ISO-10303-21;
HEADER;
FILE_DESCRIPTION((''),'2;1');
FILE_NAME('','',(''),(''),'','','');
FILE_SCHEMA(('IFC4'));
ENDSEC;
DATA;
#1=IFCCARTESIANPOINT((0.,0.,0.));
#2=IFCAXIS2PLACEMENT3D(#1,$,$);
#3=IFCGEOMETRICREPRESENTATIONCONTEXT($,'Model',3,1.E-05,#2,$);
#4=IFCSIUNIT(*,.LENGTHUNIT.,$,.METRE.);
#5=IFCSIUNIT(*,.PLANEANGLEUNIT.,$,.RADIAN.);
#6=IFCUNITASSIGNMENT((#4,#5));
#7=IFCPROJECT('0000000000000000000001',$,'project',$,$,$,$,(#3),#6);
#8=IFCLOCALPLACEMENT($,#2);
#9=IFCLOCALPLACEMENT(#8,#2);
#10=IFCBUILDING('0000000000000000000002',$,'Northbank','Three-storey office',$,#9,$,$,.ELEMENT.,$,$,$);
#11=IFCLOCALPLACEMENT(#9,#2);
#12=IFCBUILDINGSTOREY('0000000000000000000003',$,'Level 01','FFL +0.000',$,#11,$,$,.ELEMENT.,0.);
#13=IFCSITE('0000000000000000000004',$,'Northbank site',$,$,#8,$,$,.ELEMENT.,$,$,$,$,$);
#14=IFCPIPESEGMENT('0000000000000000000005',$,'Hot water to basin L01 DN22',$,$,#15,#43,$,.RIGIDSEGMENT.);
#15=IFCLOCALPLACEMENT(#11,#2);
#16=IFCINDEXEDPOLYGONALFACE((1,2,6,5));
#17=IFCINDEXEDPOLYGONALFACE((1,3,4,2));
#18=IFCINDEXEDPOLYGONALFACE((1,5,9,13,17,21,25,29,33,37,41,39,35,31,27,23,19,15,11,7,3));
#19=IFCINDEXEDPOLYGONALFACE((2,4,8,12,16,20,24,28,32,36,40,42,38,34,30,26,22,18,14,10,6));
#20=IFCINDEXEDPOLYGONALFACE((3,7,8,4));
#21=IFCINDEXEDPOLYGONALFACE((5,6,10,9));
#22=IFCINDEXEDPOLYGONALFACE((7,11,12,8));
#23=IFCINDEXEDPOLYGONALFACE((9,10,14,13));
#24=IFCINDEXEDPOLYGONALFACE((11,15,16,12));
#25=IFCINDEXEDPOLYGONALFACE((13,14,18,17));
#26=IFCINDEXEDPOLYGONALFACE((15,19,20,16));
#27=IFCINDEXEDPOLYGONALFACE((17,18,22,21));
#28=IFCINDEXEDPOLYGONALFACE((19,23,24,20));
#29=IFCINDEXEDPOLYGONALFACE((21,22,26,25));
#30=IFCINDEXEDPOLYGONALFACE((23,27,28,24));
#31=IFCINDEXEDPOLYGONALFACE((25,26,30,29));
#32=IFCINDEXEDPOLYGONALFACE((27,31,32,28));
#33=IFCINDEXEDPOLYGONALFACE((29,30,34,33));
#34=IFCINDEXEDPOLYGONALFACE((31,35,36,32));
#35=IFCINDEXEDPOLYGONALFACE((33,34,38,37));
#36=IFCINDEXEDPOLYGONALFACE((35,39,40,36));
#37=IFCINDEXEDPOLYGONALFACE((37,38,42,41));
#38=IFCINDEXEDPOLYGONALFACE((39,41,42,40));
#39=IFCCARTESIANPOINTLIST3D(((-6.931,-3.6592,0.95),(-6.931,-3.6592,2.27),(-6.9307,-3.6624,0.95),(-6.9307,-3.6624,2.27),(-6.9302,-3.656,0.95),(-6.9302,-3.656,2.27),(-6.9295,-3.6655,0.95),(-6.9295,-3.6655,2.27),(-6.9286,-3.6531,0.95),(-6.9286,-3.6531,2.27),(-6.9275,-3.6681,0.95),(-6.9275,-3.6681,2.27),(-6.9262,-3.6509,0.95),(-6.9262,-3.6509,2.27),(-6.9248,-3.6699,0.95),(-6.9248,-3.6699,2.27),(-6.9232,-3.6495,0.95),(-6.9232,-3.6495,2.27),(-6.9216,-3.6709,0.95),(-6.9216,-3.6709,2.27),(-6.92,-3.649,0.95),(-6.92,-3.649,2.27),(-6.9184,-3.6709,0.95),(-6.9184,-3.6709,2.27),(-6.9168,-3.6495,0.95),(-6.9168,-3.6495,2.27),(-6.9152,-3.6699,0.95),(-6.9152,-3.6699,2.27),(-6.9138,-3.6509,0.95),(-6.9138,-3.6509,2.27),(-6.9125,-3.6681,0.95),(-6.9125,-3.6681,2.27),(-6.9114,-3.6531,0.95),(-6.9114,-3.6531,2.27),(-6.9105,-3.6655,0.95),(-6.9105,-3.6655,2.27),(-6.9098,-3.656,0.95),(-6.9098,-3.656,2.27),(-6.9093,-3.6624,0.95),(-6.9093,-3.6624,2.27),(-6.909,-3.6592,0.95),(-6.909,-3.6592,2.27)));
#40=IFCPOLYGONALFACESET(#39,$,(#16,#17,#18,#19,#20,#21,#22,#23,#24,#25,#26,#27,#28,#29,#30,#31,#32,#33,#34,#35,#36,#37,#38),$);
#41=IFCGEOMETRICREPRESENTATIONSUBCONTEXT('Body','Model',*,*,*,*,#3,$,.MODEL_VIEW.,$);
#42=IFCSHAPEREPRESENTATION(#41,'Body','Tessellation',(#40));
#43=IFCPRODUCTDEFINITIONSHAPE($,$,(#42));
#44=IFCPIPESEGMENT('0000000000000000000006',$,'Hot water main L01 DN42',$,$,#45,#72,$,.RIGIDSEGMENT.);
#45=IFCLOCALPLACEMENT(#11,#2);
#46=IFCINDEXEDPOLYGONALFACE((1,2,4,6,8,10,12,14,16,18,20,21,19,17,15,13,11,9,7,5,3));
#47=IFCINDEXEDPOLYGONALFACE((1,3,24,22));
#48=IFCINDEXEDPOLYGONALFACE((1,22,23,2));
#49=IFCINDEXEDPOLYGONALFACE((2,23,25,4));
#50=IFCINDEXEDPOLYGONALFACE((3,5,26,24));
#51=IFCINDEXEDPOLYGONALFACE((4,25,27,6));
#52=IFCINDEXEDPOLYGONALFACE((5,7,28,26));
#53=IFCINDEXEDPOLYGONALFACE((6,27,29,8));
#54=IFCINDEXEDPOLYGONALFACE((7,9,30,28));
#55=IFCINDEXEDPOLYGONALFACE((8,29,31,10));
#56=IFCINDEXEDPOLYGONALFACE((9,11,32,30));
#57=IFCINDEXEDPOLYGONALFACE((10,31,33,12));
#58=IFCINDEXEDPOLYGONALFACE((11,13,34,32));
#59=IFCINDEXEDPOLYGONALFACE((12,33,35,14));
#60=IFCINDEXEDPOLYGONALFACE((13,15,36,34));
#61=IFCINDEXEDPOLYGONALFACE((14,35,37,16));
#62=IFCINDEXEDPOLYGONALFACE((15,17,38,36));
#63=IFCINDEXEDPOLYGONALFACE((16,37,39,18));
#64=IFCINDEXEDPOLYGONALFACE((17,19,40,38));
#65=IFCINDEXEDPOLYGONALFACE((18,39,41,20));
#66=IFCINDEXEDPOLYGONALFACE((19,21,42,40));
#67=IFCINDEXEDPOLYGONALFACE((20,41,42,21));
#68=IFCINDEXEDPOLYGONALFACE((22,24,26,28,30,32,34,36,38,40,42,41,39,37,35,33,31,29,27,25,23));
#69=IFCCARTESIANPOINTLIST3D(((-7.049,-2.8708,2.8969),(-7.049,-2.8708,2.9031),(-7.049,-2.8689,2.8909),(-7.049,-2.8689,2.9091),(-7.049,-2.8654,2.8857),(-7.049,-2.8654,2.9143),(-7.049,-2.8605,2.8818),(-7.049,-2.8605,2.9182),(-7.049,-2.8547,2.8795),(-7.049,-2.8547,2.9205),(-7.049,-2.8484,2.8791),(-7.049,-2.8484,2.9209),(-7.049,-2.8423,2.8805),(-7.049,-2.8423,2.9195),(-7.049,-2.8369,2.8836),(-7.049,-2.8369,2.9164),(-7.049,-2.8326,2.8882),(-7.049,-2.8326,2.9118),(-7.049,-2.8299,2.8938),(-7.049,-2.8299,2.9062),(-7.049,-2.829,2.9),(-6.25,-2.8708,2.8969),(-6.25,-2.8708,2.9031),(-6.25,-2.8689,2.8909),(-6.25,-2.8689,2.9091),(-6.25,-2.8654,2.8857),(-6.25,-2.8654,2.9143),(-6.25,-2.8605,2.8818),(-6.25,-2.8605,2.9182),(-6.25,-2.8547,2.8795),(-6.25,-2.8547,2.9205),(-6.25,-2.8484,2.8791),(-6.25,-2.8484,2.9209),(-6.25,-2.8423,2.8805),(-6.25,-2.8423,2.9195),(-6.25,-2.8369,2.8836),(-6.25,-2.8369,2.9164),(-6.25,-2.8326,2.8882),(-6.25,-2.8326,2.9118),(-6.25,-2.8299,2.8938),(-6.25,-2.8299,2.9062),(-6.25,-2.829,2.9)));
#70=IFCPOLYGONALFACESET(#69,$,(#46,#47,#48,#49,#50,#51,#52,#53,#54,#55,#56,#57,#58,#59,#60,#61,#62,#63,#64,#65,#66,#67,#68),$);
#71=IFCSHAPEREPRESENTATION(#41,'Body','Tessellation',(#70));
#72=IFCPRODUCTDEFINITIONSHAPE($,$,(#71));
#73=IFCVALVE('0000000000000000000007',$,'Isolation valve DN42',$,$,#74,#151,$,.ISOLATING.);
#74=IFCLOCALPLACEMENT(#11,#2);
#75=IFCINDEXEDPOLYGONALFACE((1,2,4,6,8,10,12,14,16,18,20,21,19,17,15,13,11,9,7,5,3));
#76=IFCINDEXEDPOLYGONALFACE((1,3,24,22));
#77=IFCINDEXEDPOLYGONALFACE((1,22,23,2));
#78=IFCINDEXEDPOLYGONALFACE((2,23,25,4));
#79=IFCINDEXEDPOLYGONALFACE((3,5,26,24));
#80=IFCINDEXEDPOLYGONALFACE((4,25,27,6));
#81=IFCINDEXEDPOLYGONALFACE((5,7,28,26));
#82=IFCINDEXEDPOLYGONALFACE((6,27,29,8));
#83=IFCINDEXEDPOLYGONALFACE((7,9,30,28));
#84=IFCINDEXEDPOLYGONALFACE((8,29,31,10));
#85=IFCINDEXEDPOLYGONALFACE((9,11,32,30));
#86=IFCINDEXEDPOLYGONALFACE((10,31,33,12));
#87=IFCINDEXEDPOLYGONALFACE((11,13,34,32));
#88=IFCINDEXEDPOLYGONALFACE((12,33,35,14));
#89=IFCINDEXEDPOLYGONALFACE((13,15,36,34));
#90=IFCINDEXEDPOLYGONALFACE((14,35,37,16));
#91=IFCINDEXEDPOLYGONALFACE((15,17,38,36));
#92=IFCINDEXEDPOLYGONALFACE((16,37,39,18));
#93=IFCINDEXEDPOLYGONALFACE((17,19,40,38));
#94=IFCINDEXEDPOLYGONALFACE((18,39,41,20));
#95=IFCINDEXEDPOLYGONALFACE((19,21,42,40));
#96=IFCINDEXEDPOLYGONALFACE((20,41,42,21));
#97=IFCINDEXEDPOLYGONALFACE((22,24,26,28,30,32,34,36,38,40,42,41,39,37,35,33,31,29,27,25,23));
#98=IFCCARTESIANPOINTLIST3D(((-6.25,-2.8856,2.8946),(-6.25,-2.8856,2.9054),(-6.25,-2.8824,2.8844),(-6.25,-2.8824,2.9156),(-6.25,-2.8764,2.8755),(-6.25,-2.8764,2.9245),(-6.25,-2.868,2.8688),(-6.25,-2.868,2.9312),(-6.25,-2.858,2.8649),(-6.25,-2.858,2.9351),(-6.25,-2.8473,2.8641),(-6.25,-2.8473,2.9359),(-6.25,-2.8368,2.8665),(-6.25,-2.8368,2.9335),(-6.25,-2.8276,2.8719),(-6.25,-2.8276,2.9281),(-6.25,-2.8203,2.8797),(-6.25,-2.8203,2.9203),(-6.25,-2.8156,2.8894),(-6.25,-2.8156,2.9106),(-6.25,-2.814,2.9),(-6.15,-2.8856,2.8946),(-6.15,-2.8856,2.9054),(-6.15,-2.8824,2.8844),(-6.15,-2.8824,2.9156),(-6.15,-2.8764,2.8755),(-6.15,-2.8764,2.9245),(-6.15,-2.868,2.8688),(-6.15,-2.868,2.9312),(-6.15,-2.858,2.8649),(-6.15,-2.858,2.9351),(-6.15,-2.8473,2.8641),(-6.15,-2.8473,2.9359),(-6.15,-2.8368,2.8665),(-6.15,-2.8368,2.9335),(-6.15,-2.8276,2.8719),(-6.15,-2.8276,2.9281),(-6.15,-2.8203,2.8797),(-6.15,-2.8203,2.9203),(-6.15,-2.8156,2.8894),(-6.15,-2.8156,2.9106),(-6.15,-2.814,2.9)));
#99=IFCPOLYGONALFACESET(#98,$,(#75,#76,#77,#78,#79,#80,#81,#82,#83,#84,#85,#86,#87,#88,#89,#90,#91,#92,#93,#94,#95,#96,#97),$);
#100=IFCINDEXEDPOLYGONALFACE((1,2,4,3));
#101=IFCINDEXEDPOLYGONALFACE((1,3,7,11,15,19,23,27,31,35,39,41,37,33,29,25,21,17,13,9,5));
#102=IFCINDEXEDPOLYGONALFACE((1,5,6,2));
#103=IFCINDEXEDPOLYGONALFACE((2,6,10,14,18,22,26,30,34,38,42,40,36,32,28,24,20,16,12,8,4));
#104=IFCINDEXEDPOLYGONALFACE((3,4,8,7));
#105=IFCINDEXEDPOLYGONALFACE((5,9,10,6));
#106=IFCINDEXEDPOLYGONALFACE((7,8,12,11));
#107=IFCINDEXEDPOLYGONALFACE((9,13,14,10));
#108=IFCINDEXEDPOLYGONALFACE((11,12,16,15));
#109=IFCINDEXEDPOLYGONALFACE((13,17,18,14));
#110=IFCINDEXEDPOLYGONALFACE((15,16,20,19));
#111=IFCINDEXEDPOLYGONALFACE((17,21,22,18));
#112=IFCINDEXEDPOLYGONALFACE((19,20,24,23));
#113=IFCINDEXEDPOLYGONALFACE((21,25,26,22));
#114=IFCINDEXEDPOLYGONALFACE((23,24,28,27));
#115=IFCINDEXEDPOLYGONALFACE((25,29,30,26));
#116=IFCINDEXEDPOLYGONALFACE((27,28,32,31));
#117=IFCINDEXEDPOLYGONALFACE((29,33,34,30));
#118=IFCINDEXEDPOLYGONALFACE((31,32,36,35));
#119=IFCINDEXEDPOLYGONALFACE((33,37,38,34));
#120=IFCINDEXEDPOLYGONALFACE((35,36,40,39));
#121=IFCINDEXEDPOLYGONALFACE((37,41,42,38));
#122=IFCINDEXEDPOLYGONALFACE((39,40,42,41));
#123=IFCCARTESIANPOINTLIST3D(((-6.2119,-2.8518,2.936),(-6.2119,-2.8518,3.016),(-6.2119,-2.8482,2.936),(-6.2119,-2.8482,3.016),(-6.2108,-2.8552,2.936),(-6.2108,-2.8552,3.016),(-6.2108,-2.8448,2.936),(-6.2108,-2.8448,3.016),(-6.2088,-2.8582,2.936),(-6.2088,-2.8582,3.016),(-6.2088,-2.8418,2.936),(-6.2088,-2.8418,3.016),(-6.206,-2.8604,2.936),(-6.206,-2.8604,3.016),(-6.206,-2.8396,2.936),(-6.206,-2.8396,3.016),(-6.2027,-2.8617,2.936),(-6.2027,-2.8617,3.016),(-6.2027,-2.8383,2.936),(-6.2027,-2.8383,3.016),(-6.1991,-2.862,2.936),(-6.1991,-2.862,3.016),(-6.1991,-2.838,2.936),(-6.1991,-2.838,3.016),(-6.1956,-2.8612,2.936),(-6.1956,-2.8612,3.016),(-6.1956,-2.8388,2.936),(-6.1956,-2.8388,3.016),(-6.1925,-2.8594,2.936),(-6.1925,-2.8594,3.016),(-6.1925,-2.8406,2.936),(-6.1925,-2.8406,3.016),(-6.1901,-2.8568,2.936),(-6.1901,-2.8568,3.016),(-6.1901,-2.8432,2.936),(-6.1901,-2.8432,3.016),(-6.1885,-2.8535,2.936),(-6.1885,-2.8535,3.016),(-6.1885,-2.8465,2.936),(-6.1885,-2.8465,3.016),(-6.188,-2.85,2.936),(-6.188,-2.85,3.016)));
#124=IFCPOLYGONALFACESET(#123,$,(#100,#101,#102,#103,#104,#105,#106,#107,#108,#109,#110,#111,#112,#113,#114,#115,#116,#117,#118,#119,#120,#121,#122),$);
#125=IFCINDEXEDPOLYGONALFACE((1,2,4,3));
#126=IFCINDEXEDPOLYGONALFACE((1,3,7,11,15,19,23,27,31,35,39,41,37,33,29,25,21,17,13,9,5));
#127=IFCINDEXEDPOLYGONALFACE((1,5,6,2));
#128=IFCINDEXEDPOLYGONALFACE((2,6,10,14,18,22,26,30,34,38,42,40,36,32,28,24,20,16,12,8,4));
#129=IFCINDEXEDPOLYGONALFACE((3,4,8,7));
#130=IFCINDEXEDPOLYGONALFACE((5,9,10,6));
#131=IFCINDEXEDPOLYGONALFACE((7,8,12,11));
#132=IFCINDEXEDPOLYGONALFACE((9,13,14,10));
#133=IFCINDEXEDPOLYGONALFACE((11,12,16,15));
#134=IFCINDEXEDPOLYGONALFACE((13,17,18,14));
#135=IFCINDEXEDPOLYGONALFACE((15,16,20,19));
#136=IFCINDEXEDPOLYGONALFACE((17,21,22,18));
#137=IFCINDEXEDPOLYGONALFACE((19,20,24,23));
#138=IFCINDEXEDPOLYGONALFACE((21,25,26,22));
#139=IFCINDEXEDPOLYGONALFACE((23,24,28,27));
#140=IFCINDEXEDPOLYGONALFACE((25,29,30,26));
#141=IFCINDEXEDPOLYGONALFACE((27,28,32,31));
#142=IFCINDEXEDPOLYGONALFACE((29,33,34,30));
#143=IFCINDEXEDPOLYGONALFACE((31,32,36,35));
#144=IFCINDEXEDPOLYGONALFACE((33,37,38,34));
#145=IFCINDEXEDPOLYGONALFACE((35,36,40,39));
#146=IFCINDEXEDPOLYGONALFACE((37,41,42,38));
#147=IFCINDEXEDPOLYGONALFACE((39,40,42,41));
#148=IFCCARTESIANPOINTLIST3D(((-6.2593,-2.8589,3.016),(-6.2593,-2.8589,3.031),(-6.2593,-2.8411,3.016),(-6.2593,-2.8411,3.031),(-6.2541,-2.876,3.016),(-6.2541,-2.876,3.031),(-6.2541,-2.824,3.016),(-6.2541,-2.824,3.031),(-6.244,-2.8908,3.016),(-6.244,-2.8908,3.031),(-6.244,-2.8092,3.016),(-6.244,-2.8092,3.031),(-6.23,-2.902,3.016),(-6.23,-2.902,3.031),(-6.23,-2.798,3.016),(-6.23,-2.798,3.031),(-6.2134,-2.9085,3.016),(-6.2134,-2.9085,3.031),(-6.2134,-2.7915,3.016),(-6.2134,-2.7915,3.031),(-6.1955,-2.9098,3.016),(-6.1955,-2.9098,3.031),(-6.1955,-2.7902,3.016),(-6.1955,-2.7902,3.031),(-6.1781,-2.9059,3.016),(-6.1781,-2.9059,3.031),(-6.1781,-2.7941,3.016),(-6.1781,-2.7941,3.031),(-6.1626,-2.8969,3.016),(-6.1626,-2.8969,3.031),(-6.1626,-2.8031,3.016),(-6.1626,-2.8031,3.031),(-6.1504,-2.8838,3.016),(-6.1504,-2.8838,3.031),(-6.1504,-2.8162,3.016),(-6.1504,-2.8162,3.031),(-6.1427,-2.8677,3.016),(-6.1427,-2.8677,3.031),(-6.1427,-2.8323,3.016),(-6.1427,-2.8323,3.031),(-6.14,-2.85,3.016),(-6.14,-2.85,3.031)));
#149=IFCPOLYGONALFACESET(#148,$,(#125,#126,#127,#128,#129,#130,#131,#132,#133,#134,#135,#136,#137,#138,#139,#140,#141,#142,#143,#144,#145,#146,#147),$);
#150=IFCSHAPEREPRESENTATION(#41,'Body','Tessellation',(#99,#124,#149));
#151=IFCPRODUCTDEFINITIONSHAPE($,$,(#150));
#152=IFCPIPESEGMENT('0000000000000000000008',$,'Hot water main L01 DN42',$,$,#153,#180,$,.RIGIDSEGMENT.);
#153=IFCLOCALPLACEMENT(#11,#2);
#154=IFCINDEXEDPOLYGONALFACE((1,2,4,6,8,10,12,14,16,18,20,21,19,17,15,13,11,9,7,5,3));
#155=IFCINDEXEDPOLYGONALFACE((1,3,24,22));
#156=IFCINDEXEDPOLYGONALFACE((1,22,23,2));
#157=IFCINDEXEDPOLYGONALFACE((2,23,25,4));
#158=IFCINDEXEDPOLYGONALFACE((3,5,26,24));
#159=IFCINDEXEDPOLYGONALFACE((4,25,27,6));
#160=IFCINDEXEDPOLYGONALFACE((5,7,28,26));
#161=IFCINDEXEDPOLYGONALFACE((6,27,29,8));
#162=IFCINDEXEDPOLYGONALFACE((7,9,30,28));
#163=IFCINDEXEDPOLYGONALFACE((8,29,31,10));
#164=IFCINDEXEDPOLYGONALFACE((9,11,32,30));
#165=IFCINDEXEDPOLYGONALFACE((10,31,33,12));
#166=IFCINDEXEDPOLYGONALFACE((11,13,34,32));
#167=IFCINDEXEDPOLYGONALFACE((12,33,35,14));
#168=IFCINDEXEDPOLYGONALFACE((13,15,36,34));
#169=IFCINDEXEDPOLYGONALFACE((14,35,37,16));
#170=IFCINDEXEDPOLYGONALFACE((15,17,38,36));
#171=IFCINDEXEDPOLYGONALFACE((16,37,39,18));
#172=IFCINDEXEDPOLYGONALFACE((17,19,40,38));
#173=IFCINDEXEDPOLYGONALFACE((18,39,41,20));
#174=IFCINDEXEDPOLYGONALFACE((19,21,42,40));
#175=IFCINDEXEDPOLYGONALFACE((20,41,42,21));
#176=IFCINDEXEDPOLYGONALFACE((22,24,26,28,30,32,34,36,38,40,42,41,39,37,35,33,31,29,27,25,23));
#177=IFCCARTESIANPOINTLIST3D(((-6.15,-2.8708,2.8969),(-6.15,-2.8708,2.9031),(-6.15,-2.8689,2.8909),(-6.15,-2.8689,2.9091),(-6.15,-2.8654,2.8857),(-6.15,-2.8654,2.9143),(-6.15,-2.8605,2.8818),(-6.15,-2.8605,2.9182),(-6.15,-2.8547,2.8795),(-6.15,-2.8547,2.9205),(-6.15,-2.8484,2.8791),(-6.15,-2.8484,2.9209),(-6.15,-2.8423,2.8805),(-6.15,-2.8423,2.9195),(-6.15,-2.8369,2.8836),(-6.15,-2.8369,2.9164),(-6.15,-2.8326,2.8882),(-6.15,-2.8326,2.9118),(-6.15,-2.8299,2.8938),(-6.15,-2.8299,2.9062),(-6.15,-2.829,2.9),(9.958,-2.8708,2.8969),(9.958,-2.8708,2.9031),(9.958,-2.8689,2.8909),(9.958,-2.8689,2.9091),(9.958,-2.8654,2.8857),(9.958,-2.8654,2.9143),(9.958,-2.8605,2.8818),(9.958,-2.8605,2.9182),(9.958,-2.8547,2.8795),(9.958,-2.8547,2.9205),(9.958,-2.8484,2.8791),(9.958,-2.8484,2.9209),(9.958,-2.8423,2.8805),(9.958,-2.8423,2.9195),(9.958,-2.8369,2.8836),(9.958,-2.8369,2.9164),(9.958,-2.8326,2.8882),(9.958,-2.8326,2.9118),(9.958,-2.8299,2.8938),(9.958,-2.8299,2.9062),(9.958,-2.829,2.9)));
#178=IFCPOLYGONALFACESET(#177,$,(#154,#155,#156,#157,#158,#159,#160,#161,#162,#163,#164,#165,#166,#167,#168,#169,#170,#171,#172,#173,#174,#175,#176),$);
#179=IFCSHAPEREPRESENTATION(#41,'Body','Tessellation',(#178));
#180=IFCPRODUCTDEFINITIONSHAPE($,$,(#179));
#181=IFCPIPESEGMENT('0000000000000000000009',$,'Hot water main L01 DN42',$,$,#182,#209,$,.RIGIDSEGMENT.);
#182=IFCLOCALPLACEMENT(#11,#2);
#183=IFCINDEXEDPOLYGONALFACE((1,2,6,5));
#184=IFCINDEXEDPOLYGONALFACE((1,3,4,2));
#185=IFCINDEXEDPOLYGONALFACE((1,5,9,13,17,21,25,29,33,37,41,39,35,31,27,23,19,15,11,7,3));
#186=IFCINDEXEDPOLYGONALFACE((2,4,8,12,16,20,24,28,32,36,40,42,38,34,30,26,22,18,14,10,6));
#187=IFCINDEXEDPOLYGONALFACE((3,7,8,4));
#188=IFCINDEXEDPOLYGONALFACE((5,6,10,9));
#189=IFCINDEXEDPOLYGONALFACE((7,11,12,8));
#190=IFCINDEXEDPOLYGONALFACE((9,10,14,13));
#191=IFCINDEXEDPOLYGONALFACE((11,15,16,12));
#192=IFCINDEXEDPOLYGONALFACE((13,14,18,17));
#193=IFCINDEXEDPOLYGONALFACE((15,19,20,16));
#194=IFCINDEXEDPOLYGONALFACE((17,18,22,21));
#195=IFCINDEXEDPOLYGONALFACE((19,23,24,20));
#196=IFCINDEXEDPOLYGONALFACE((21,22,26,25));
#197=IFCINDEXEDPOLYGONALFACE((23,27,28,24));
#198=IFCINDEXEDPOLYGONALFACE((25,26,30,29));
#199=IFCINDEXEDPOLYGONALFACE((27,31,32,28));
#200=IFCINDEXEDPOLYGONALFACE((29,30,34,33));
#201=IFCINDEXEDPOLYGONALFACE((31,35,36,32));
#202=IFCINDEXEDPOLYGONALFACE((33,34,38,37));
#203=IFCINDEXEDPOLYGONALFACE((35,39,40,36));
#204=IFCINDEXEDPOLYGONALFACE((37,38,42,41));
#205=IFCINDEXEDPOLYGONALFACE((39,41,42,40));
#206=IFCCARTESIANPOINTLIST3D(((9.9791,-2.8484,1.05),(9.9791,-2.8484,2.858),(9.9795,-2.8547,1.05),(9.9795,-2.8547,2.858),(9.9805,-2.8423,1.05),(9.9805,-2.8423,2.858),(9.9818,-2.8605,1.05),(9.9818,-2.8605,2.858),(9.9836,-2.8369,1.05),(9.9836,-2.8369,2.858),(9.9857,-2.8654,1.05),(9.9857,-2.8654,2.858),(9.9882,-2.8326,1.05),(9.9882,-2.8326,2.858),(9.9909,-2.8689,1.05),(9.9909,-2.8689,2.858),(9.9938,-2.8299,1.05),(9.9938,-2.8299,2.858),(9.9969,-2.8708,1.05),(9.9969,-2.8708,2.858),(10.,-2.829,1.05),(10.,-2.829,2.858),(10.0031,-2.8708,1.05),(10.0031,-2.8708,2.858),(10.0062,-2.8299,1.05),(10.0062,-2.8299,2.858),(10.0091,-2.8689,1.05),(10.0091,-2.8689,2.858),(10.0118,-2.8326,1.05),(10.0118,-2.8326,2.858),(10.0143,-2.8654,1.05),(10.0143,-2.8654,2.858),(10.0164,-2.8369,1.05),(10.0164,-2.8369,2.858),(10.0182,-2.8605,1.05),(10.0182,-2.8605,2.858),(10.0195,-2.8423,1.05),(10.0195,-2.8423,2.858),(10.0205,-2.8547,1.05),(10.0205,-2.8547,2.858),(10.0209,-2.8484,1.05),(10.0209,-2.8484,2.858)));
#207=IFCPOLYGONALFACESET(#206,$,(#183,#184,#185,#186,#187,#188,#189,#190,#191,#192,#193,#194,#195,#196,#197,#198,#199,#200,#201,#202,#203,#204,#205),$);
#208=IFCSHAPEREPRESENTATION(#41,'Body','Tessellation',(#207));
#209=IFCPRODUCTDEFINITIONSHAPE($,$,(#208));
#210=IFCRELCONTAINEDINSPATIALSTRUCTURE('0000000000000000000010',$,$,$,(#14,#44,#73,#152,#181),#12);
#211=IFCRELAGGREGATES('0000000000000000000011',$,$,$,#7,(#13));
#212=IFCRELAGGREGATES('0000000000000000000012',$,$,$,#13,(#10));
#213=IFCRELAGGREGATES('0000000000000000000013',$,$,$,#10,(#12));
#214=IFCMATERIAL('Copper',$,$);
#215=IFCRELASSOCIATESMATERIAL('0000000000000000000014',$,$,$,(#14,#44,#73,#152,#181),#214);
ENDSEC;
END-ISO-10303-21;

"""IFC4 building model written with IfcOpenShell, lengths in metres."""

from ifc_helpers import new_model, si_unit, frame, origin, place, context, subcontext, project, spatial, circle, extrude, material, element, save


model = new_model("IFC4")

# Units and contexts
model_context = context("Model", 3, precision=1e-05, world=origin())
body_context = subcontext(model_context, "Body", "Model", "MODEL_VIEW")
ifc_project = project(units=[si_unit("LENGTHUNIT", "METRE"), si_unit("PLANEANGLEUNIT", "RADIAN")], contexts=[model_context])

# Site, building, storey
site_placement = place(None, origin())
site = spatial("IfcSite", under=ifc_project, at=site_placement, Name="Northbank site", CompositionType="ELEMENT")
building_placement = place(site_placement, origin())
building = spatial("IfcBuilding", under=site, at=building_placement, Name="Northbank", Description="Three-storey office", CompositionType="ELEMENT")
storey_placement = place(building_placement, origin())
storey = spatial("IfcBuildingStorey", under=building, at=storey_placement, Name="Level 01", Description="FFL +0.000", CompositionType="ELEMENT", Elevation=0.0)

# Pipe segments
ifc_material_1 = material(Name="Copper")
pipe_segment_1_placement = place(storey_placement, origin())
element("IfcPipeSegment", 1, at=pipe_segment_1_placement, inside=storey, material=ifc_material_1, Name="Hot water to basin L01 DN22", PredefinedType="RIGIDSEGMENT", context=body_context, shape_type="SweptSolid", body=[
    extrude(circle(Radius=0.011), frame((-6.92, -3.66, 2.27), z_axis=(0.0, 0.0, -1.0), x_axis=(0.0, 1.0, 0.0)), (0.0, 0.0, 1.0), 1.32),
])
pipe_segment_2_placement = place(storey_placement, origin())
element("IfcPipeSegment", 2, at=pipe_segment_2_placement, inside=storey, material=ifc_material_1, Name="Hot water main L01 DN42", PredefinedType="RIGIDSEGMENT", context=body_context, shape_type="SweptSolid", body=[
    extrude(circle(Radius=0.021), frame((-7.049, -2.85, 2.9), z_axis=(1.0, 0.0, 0.0), x_axis=(0.0, 1.0, 0.0)), (0.0, 0.0, 1.0), 0.799),
])

# Valve
valve_placement = place(storey_placement, origin())
element("IfcValve", 3, at=valve_placement, inside=storey, material=ifc_material_1, Name="Isolation valve DN42", PredefinedType="ISOLATING", context=body_context, shape_type="SweptSolid", body=[
    extrude(circle(Radius=0.036), frame((-6.25, -2.85, 2.9), z_axis=(1.0, 0.0, 0.0), x_axis=(0.0, 1.0, 0.0)), (0.0, 0.0, 1.0), 0.1),
    extrude(circle(Radius=0.012), frame((-6.2, -2.85, 2.936), z_axis=(0.0, 0.0, 1.0), x_axis=(1.0, 0.0, 0.0)), (0.0, 0.0, 1.0), 0.08),
    extrude(circle(Radius=0.06), frame((-6.2, -2.85, 3.016), z_axis=(0.0, 0.0, 1.0), x_axis=(1.0, 0.0, 0.0)), (0.0, 0.0, 1.0), 0.015),
])

# Pipe segments
pipe_segment_3_placement = place(storey_placement, origin())
element("IfcPipeSegment", 4, at=pipe_segment_3_placement, inside=storey, material=ifc_material_1, Name="Hot water main L01 DN42", PredefinedType="RIGIDSEGMENT", context=body_context, shape_type="SweptSolid", body=[
    extrude(circle(Radius=0.021), frame((-6.15, -2.85, 2.9), z_axis=(1.0, 0.0, 0.0), x_axis=(0.0, 1.0, 0.0)), (0.0, 0.0, 1.0), 16.108),
])
pipe_segment_4_placement = place(storey_placement, origin())
element("IfcPipeSegment", 5, at=pipe_segment_4_placement, inside=storey, material=ifc_material_1, Name="Hot water main L01 DN42", PredefinedType="RIGIDSEGMENT", context=body_context, shape_type="SweptSolid", body=[
    extrude(circle(Radius=0.021), frame((10.0, -2.85, 2.858), z_axis=(0.0, 0.0, -1.0), x_axis=(0.0, 1.0, 0.0)), (0.0, 0.0, 1.0), 1.808),
])

save(model, "model.ifc")
